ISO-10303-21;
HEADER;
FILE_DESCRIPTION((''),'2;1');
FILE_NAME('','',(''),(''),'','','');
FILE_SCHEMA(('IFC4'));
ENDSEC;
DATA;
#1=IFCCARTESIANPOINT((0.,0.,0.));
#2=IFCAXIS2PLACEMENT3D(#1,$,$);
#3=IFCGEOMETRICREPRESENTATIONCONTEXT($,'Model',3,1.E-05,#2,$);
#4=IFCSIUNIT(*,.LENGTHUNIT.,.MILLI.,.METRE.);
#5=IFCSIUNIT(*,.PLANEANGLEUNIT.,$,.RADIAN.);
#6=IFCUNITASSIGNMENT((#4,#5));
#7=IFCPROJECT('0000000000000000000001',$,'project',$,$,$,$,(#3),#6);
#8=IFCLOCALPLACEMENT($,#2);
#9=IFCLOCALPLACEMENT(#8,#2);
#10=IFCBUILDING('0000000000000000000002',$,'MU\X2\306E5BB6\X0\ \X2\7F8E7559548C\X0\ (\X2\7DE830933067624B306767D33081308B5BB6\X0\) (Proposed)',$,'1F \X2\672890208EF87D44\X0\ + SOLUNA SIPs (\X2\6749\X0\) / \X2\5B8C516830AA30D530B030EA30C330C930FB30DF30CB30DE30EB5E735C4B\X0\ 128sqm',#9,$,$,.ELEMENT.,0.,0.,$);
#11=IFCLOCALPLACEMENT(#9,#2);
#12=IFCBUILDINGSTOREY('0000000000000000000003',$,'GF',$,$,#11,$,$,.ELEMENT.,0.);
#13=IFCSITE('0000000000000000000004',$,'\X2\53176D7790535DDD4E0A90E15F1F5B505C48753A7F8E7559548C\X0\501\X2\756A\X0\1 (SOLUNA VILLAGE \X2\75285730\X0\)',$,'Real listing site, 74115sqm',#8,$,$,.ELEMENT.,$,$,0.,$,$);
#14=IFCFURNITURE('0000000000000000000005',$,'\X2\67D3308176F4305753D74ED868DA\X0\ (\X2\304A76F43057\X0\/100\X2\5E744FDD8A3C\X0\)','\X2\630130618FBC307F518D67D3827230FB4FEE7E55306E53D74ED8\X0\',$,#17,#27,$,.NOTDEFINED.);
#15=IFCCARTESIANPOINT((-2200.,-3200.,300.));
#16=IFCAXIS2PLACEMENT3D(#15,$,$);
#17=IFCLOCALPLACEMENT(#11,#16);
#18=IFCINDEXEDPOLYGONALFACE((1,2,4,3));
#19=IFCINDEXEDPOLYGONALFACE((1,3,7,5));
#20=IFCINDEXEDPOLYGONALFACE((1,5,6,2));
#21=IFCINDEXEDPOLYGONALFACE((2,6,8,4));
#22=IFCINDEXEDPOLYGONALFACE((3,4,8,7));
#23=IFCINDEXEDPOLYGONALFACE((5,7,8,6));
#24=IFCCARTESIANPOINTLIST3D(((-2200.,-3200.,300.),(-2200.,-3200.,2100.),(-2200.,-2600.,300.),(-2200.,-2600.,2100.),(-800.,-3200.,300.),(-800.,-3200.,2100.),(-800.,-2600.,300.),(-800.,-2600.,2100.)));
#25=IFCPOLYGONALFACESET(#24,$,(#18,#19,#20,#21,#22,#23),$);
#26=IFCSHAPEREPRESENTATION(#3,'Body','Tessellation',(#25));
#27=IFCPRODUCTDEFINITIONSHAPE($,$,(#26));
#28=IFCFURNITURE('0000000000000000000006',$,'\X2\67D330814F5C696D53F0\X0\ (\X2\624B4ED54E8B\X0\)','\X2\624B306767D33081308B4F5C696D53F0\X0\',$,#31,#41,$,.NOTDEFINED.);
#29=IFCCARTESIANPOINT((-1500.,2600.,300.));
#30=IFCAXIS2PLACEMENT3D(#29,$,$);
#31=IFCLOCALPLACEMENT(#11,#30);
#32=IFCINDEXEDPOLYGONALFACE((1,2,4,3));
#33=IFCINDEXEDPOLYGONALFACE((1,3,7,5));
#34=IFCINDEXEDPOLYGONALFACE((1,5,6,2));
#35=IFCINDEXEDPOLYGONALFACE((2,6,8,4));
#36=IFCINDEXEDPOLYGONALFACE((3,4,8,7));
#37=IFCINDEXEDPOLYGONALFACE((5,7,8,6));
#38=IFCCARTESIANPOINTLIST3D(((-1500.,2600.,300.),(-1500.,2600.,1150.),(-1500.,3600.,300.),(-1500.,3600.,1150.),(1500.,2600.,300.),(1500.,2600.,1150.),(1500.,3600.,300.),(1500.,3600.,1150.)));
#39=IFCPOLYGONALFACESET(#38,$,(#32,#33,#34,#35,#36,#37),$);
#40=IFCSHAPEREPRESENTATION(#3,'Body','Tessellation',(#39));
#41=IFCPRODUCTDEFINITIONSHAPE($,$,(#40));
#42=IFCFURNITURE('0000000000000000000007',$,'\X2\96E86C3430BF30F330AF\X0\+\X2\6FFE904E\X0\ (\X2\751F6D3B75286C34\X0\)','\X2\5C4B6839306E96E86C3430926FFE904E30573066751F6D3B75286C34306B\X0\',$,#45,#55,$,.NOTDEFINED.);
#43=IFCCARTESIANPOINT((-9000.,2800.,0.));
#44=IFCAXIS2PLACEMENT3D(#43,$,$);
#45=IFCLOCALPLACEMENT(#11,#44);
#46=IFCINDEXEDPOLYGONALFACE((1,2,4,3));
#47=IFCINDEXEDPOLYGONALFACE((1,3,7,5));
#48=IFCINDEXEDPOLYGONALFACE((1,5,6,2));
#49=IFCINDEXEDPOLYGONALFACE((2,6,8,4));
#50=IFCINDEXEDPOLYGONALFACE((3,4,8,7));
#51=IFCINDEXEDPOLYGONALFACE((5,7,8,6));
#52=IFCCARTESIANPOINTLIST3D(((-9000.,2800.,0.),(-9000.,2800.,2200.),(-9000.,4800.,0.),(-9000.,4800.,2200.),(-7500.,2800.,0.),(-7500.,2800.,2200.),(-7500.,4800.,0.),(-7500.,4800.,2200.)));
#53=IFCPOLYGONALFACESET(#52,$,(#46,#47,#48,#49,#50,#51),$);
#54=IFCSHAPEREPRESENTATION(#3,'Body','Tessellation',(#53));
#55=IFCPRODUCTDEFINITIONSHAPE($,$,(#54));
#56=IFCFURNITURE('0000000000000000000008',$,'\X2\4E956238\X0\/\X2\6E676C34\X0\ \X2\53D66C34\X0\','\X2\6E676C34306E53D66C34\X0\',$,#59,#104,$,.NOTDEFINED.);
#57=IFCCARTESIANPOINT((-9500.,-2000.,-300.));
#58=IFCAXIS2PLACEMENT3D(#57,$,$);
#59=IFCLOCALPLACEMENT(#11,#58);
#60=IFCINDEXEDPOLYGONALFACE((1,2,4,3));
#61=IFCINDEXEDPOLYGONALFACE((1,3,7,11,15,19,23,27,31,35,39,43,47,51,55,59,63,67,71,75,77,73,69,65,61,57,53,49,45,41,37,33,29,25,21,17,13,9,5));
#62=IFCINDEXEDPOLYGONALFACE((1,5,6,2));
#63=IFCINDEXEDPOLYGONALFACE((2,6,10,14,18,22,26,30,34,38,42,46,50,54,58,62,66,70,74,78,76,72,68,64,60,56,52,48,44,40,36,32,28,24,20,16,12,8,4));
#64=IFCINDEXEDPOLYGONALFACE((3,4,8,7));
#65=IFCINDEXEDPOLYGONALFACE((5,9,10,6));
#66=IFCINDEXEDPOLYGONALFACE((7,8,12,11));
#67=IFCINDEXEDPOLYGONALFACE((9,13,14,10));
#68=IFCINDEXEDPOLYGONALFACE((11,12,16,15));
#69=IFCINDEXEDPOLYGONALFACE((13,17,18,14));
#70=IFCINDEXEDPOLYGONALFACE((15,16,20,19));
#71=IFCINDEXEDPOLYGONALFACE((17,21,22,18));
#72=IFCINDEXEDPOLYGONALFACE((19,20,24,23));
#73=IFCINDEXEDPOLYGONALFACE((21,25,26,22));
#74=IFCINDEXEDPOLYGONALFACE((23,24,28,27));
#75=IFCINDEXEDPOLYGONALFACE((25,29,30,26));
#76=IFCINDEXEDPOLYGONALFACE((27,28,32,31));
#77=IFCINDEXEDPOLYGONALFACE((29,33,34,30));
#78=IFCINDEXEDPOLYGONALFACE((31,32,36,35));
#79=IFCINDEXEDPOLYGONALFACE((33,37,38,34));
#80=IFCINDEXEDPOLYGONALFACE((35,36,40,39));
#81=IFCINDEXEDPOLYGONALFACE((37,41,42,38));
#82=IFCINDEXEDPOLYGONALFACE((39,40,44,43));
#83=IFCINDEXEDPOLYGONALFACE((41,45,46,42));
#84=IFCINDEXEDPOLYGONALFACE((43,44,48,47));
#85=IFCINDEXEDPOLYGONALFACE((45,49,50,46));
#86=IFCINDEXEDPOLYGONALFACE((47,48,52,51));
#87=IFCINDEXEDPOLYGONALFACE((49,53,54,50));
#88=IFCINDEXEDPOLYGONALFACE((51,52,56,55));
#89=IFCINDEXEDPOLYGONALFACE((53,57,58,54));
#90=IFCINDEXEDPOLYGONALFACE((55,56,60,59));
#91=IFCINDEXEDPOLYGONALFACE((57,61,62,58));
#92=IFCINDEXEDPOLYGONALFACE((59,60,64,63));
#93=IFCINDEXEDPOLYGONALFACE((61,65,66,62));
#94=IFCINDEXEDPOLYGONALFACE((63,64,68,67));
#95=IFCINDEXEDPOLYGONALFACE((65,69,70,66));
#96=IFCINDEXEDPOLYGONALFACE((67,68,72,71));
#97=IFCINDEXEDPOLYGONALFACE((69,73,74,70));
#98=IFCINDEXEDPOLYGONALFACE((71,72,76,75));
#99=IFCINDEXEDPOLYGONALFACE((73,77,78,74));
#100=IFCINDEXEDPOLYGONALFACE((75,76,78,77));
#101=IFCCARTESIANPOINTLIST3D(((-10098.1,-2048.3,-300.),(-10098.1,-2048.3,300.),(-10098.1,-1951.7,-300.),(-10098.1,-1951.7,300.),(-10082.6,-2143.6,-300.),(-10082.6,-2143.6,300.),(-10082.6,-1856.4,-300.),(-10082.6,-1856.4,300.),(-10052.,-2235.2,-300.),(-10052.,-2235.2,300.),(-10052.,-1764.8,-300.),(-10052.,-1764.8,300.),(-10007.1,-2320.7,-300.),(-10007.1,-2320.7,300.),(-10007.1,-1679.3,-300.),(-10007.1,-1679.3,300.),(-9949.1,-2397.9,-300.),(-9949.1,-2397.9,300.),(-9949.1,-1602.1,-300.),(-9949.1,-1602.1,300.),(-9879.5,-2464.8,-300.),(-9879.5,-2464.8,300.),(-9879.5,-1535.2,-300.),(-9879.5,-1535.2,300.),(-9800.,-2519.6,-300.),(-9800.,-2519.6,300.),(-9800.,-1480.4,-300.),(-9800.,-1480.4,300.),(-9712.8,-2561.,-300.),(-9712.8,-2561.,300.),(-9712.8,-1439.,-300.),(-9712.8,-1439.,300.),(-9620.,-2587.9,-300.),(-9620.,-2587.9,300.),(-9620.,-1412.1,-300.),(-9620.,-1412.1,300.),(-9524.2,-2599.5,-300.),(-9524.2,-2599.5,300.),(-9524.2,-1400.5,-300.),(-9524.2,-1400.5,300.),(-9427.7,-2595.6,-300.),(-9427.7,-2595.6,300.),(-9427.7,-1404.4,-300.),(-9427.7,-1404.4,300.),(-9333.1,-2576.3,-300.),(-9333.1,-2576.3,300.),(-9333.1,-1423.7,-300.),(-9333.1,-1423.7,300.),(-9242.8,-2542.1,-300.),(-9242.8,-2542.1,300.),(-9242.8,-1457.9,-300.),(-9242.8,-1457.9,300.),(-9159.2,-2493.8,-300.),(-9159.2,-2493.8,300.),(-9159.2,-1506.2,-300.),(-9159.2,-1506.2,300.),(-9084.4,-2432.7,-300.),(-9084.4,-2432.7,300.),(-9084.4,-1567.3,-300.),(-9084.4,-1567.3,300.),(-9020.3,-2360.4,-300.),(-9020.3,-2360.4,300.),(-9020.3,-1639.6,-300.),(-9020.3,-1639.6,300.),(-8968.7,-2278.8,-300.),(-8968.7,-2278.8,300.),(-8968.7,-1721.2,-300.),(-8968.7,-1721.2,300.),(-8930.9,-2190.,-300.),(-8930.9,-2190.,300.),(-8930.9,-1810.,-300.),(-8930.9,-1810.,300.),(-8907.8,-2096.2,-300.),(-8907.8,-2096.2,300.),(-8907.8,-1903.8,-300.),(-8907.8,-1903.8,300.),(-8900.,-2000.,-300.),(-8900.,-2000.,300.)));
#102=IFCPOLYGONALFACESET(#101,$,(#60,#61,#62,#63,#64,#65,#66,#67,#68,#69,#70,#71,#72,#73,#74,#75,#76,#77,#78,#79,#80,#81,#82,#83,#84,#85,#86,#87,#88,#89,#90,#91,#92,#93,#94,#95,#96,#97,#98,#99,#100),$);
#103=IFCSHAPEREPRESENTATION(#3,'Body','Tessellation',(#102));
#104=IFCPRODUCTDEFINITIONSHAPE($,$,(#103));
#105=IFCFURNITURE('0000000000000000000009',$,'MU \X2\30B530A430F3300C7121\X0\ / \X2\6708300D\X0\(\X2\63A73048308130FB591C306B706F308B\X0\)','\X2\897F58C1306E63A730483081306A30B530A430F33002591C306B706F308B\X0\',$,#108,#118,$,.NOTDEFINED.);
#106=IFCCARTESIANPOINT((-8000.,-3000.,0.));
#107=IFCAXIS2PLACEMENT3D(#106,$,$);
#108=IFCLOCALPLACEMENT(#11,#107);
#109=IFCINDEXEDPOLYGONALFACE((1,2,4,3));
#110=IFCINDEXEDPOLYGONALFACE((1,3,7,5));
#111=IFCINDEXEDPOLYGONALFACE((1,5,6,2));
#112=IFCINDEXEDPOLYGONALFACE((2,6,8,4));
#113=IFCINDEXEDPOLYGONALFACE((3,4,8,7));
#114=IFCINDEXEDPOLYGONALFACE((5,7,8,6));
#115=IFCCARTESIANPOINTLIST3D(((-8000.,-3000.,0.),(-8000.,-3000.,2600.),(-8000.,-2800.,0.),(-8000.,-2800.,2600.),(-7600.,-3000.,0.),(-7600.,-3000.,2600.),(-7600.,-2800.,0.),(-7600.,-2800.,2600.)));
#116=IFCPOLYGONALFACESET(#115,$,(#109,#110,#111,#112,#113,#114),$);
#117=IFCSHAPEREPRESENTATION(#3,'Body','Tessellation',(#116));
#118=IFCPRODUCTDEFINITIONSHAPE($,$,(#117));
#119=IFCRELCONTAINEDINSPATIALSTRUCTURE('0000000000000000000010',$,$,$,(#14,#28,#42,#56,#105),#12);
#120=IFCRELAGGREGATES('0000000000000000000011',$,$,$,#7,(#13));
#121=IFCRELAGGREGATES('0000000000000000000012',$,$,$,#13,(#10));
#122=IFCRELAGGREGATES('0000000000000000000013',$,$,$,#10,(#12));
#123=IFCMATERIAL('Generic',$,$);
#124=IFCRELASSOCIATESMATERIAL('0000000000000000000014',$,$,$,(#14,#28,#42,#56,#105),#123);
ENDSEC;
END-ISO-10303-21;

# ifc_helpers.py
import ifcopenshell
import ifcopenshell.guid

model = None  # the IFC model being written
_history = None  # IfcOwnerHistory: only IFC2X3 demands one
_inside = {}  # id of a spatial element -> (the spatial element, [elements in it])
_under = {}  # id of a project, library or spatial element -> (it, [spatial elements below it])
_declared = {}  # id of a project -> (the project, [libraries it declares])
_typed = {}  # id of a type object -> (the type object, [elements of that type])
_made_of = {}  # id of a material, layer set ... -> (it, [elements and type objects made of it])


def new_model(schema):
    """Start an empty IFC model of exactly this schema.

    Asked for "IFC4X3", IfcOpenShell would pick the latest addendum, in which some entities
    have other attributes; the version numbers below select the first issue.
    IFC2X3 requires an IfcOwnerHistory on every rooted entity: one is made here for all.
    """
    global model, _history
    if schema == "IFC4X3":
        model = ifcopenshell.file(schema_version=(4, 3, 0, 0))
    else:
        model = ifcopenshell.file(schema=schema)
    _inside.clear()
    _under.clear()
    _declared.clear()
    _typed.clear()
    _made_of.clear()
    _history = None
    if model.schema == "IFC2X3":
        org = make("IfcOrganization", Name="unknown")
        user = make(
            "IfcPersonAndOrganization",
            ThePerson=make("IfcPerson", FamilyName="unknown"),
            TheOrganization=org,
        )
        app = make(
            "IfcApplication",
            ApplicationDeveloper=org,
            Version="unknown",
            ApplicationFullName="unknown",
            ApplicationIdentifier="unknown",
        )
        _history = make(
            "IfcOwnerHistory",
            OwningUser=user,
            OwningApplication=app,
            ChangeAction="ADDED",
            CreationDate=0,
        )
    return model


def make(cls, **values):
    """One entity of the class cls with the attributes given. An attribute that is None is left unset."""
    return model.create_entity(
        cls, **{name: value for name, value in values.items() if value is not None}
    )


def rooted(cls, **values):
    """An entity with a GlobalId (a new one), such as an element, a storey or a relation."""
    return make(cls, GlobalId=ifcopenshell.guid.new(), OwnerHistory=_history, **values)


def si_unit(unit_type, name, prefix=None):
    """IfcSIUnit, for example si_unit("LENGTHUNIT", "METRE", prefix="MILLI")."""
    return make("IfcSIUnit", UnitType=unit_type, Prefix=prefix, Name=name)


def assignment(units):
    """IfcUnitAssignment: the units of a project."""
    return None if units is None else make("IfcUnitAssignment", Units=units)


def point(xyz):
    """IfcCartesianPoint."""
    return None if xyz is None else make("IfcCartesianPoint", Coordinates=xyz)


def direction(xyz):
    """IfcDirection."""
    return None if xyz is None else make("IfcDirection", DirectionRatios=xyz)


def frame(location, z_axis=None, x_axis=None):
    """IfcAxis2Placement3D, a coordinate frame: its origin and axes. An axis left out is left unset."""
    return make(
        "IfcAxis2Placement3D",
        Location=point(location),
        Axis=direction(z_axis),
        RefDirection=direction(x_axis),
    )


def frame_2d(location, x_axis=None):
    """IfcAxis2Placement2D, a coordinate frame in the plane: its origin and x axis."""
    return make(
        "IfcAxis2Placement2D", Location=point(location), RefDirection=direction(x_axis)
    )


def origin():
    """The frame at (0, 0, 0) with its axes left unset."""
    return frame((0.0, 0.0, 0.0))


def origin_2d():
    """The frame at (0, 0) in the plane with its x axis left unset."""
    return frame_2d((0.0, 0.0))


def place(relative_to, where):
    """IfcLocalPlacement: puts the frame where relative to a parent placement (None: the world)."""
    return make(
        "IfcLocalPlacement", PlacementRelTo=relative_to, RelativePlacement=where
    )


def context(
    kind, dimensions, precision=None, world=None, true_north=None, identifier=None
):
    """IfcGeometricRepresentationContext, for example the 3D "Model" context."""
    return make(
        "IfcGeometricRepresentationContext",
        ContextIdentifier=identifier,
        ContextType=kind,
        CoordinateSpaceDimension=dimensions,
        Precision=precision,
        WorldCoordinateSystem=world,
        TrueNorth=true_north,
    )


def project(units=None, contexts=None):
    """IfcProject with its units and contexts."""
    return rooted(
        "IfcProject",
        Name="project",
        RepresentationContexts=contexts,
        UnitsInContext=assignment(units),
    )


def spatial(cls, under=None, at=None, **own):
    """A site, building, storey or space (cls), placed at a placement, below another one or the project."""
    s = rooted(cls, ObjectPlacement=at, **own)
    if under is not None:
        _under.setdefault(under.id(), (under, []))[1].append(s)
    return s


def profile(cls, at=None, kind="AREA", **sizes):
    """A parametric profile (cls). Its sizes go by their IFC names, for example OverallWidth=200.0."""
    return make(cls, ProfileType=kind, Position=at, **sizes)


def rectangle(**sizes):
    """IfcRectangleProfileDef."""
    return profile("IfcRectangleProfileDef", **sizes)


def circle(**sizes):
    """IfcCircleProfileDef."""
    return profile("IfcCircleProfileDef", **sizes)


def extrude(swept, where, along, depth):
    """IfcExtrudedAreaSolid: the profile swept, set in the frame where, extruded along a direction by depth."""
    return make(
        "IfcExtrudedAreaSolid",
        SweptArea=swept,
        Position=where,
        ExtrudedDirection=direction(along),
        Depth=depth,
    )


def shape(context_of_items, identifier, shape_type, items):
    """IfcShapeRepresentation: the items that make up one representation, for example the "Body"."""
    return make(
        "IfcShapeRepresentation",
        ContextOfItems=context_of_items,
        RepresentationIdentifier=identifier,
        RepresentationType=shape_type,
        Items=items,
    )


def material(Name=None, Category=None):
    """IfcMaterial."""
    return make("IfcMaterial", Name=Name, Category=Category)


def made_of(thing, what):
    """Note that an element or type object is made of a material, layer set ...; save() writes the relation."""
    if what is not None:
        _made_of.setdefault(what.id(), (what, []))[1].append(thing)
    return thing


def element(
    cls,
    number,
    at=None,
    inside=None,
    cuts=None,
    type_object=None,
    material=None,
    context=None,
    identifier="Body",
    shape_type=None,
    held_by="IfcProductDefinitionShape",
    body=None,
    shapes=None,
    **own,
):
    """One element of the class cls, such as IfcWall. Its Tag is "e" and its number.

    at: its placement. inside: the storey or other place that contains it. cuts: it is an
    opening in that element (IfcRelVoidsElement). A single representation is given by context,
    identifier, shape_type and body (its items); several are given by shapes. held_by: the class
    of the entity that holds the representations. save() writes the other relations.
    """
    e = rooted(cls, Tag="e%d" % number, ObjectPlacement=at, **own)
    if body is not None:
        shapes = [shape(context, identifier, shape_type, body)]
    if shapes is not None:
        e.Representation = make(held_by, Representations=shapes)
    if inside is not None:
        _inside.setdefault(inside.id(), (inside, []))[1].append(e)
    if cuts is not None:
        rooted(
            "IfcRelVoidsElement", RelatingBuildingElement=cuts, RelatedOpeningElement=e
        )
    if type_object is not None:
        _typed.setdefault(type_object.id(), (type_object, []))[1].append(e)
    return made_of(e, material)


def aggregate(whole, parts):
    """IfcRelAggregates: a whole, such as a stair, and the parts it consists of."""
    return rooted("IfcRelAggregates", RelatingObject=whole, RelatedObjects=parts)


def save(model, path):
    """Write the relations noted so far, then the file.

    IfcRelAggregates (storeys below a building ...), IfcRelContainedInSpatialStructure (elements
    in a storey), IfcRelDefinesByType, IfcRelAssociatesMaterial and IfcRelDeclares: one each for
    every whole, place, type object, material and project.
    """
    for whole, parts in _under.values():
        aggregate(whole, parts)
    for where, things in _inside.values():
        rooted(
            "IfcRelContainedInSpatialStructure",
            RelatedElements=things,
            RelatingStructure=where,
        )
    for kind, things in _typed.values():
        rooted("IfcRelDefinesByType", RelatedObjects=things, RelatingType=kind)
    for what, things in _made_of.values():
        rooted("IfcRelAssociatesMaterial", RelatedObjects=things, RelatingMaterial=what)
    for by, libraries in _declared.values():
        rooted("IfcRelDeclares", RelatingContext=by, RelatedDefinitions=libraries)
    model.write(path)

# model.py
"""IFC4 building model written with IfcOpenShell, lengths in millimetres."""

from ifc_helpers import new_model, si_unit, frame, frame_2d, origin, origin_2d, place, context, project, spatial, rectangle, circle, extrude, material, element, save


model = new_model("IFC4")

# Units and contexts
model_context = context("Model", 3, precision=1e-05, world=origin())
ifc_project = project(units=[si_unit("LENGTHUNIT", "METRE", prefix="MILLI"), si_unit("PLANEANGLEUNIT", "RADIAN")], contexts=[model_context])

# Site, building, storey
site_placement = place(None, origin())
site = spatial("IfcSite", under=ifc_project, at=site_placement, Name="北海道川上郡弟子屈町美留和501番1 (SOLUNA VILLAGE 用地)", ObjectType="Real listing site, 74115sqm", CompositionType="ELEMENT", RefElevation=0.0)
building_placement = place(site_placement, origin())
building = spatial("IfcBuilding", under=site, at=building_placement, Name="MUの家 美留和 (編んで手で染める家) (Proposed)", ObjectType="1F 木造軸組 + SOLUNA SIPs (杉) / 完全オフグリッド・ミニマル平屋 128sqm", CompositionType="ELEMENT", ElevationOfRefHeight=0.0, ElevationOfTerrain=0.0)
storey_placement = place(building_placement, origin())
storey = spatial("IfcBuildingStorey", under=building, at=storey_placement, Name="GF", CompositionType="ELEMENT", Elevation=0.0)

# Shared definitions
ifc_material_1 = material(Name="Generic")

# Furniture
furniture_1_placement = place(storey_placement, frame((-2200.0, -3200.0, 300.0)))
element("IfcFurniture", 1, at=furniture_1_placement, inside=storey, material=ifc_material_1, Name="染め直し受付棚 (お直し/100年保証)", Description="持ち込み再染色・修繕の受付", PredefinedType="NOTDEFINED", context=model_context, shape_type="SweptSolid", body=[
    extrude(rectangle(XDim=1400.0, YDim=600.0, at=frame_2d((700.0, 300.0))), frame((-2200.0, -3200.0, 300.0)), (0.0, 0.0, 1.0), 1800.0),
])
furniture_2_placement = place(storey_placement, frame((-1500.0, 2600.0, 300.0)))
element("IfcFurniture", 2, at=furniture_2_placement, inside=storey, material=ifc_material_1, Name="染め作業台 (手仕事)", Description="手で染める作業台", PredefinedType="NOTDEFINED", context=model_context, shape_type="SweptSolid", body=[
    extrude(rectangle(XDim=3000.0, YDim=1000.0, at=frame_2d((1500.0, 500.0))), frame((-1500.0, 2600.0, 300.0)), (0.0, 0.0, 1.0), 850.0),
])
furniture_3_placement = place(storey_placement, frame((-9000.0, 2800.0, 0.0)))
element("IfcFurniture", 3, at=furniture_3_placement, inside=storey, material=ifc_material_1, Name="雨水タンク+濾過 (生活用水)", Description="屋根の雨水を濾過して生活用水に", PredefinedType="NOTDEFINED", context=model_context, shape_type="SweptSolid", body=[
    extrude(rectangle(XDim=1500.0, YDim=2000.0, at=frame_2d((750.0, 1000.0))), frame((-9000.0, 2800.0, 0.0)), (0.0, 0.0, 1.0), 2200.0),
])
furniture_4_placement = place(storey_placement, frame((-9500.0, -2000.0, -300.0)))
element("IfcFurniture", 4, at=furniture_4_placement, inside=storey, material=ifc_material_1, Name="井戸/湧水 取水", Description="湧水の取水", PredefinedType="NOTDEFINED", context=model_context, shape_type="SweptSolid", body=[
    extrude(circle(Radius=600.0, at=origin_2d()), frame((-9500.0, -2000.0, -300.0)), (0.0, 0.0, 1.0), 600.0),
])
furniture_5_placement = place(storey_placement, frame((-8000.0, -3000.0, 0.0)))
element("IfcFurniture", 5, at=furniture_5_placement, inside=storey, material=ifc_material_1, Name="MU サイン「無 / 月」(控えめ・夜に灯る)", Description="西壁の控えめなサイン。夜に灯る", PredefinedType="NOTDEFINED", context=model_context, shape_type="SweptSolid", body=[
    extrude(rectangle(XDim=400.0, YDim=200.0, at=frame_2d((200.0, 100.0))), frame((-8000.0, -3000.0, 0.0)), (0.0, 0.0, 1.0), 2600.0),
])

save(model, "model.ifc")
